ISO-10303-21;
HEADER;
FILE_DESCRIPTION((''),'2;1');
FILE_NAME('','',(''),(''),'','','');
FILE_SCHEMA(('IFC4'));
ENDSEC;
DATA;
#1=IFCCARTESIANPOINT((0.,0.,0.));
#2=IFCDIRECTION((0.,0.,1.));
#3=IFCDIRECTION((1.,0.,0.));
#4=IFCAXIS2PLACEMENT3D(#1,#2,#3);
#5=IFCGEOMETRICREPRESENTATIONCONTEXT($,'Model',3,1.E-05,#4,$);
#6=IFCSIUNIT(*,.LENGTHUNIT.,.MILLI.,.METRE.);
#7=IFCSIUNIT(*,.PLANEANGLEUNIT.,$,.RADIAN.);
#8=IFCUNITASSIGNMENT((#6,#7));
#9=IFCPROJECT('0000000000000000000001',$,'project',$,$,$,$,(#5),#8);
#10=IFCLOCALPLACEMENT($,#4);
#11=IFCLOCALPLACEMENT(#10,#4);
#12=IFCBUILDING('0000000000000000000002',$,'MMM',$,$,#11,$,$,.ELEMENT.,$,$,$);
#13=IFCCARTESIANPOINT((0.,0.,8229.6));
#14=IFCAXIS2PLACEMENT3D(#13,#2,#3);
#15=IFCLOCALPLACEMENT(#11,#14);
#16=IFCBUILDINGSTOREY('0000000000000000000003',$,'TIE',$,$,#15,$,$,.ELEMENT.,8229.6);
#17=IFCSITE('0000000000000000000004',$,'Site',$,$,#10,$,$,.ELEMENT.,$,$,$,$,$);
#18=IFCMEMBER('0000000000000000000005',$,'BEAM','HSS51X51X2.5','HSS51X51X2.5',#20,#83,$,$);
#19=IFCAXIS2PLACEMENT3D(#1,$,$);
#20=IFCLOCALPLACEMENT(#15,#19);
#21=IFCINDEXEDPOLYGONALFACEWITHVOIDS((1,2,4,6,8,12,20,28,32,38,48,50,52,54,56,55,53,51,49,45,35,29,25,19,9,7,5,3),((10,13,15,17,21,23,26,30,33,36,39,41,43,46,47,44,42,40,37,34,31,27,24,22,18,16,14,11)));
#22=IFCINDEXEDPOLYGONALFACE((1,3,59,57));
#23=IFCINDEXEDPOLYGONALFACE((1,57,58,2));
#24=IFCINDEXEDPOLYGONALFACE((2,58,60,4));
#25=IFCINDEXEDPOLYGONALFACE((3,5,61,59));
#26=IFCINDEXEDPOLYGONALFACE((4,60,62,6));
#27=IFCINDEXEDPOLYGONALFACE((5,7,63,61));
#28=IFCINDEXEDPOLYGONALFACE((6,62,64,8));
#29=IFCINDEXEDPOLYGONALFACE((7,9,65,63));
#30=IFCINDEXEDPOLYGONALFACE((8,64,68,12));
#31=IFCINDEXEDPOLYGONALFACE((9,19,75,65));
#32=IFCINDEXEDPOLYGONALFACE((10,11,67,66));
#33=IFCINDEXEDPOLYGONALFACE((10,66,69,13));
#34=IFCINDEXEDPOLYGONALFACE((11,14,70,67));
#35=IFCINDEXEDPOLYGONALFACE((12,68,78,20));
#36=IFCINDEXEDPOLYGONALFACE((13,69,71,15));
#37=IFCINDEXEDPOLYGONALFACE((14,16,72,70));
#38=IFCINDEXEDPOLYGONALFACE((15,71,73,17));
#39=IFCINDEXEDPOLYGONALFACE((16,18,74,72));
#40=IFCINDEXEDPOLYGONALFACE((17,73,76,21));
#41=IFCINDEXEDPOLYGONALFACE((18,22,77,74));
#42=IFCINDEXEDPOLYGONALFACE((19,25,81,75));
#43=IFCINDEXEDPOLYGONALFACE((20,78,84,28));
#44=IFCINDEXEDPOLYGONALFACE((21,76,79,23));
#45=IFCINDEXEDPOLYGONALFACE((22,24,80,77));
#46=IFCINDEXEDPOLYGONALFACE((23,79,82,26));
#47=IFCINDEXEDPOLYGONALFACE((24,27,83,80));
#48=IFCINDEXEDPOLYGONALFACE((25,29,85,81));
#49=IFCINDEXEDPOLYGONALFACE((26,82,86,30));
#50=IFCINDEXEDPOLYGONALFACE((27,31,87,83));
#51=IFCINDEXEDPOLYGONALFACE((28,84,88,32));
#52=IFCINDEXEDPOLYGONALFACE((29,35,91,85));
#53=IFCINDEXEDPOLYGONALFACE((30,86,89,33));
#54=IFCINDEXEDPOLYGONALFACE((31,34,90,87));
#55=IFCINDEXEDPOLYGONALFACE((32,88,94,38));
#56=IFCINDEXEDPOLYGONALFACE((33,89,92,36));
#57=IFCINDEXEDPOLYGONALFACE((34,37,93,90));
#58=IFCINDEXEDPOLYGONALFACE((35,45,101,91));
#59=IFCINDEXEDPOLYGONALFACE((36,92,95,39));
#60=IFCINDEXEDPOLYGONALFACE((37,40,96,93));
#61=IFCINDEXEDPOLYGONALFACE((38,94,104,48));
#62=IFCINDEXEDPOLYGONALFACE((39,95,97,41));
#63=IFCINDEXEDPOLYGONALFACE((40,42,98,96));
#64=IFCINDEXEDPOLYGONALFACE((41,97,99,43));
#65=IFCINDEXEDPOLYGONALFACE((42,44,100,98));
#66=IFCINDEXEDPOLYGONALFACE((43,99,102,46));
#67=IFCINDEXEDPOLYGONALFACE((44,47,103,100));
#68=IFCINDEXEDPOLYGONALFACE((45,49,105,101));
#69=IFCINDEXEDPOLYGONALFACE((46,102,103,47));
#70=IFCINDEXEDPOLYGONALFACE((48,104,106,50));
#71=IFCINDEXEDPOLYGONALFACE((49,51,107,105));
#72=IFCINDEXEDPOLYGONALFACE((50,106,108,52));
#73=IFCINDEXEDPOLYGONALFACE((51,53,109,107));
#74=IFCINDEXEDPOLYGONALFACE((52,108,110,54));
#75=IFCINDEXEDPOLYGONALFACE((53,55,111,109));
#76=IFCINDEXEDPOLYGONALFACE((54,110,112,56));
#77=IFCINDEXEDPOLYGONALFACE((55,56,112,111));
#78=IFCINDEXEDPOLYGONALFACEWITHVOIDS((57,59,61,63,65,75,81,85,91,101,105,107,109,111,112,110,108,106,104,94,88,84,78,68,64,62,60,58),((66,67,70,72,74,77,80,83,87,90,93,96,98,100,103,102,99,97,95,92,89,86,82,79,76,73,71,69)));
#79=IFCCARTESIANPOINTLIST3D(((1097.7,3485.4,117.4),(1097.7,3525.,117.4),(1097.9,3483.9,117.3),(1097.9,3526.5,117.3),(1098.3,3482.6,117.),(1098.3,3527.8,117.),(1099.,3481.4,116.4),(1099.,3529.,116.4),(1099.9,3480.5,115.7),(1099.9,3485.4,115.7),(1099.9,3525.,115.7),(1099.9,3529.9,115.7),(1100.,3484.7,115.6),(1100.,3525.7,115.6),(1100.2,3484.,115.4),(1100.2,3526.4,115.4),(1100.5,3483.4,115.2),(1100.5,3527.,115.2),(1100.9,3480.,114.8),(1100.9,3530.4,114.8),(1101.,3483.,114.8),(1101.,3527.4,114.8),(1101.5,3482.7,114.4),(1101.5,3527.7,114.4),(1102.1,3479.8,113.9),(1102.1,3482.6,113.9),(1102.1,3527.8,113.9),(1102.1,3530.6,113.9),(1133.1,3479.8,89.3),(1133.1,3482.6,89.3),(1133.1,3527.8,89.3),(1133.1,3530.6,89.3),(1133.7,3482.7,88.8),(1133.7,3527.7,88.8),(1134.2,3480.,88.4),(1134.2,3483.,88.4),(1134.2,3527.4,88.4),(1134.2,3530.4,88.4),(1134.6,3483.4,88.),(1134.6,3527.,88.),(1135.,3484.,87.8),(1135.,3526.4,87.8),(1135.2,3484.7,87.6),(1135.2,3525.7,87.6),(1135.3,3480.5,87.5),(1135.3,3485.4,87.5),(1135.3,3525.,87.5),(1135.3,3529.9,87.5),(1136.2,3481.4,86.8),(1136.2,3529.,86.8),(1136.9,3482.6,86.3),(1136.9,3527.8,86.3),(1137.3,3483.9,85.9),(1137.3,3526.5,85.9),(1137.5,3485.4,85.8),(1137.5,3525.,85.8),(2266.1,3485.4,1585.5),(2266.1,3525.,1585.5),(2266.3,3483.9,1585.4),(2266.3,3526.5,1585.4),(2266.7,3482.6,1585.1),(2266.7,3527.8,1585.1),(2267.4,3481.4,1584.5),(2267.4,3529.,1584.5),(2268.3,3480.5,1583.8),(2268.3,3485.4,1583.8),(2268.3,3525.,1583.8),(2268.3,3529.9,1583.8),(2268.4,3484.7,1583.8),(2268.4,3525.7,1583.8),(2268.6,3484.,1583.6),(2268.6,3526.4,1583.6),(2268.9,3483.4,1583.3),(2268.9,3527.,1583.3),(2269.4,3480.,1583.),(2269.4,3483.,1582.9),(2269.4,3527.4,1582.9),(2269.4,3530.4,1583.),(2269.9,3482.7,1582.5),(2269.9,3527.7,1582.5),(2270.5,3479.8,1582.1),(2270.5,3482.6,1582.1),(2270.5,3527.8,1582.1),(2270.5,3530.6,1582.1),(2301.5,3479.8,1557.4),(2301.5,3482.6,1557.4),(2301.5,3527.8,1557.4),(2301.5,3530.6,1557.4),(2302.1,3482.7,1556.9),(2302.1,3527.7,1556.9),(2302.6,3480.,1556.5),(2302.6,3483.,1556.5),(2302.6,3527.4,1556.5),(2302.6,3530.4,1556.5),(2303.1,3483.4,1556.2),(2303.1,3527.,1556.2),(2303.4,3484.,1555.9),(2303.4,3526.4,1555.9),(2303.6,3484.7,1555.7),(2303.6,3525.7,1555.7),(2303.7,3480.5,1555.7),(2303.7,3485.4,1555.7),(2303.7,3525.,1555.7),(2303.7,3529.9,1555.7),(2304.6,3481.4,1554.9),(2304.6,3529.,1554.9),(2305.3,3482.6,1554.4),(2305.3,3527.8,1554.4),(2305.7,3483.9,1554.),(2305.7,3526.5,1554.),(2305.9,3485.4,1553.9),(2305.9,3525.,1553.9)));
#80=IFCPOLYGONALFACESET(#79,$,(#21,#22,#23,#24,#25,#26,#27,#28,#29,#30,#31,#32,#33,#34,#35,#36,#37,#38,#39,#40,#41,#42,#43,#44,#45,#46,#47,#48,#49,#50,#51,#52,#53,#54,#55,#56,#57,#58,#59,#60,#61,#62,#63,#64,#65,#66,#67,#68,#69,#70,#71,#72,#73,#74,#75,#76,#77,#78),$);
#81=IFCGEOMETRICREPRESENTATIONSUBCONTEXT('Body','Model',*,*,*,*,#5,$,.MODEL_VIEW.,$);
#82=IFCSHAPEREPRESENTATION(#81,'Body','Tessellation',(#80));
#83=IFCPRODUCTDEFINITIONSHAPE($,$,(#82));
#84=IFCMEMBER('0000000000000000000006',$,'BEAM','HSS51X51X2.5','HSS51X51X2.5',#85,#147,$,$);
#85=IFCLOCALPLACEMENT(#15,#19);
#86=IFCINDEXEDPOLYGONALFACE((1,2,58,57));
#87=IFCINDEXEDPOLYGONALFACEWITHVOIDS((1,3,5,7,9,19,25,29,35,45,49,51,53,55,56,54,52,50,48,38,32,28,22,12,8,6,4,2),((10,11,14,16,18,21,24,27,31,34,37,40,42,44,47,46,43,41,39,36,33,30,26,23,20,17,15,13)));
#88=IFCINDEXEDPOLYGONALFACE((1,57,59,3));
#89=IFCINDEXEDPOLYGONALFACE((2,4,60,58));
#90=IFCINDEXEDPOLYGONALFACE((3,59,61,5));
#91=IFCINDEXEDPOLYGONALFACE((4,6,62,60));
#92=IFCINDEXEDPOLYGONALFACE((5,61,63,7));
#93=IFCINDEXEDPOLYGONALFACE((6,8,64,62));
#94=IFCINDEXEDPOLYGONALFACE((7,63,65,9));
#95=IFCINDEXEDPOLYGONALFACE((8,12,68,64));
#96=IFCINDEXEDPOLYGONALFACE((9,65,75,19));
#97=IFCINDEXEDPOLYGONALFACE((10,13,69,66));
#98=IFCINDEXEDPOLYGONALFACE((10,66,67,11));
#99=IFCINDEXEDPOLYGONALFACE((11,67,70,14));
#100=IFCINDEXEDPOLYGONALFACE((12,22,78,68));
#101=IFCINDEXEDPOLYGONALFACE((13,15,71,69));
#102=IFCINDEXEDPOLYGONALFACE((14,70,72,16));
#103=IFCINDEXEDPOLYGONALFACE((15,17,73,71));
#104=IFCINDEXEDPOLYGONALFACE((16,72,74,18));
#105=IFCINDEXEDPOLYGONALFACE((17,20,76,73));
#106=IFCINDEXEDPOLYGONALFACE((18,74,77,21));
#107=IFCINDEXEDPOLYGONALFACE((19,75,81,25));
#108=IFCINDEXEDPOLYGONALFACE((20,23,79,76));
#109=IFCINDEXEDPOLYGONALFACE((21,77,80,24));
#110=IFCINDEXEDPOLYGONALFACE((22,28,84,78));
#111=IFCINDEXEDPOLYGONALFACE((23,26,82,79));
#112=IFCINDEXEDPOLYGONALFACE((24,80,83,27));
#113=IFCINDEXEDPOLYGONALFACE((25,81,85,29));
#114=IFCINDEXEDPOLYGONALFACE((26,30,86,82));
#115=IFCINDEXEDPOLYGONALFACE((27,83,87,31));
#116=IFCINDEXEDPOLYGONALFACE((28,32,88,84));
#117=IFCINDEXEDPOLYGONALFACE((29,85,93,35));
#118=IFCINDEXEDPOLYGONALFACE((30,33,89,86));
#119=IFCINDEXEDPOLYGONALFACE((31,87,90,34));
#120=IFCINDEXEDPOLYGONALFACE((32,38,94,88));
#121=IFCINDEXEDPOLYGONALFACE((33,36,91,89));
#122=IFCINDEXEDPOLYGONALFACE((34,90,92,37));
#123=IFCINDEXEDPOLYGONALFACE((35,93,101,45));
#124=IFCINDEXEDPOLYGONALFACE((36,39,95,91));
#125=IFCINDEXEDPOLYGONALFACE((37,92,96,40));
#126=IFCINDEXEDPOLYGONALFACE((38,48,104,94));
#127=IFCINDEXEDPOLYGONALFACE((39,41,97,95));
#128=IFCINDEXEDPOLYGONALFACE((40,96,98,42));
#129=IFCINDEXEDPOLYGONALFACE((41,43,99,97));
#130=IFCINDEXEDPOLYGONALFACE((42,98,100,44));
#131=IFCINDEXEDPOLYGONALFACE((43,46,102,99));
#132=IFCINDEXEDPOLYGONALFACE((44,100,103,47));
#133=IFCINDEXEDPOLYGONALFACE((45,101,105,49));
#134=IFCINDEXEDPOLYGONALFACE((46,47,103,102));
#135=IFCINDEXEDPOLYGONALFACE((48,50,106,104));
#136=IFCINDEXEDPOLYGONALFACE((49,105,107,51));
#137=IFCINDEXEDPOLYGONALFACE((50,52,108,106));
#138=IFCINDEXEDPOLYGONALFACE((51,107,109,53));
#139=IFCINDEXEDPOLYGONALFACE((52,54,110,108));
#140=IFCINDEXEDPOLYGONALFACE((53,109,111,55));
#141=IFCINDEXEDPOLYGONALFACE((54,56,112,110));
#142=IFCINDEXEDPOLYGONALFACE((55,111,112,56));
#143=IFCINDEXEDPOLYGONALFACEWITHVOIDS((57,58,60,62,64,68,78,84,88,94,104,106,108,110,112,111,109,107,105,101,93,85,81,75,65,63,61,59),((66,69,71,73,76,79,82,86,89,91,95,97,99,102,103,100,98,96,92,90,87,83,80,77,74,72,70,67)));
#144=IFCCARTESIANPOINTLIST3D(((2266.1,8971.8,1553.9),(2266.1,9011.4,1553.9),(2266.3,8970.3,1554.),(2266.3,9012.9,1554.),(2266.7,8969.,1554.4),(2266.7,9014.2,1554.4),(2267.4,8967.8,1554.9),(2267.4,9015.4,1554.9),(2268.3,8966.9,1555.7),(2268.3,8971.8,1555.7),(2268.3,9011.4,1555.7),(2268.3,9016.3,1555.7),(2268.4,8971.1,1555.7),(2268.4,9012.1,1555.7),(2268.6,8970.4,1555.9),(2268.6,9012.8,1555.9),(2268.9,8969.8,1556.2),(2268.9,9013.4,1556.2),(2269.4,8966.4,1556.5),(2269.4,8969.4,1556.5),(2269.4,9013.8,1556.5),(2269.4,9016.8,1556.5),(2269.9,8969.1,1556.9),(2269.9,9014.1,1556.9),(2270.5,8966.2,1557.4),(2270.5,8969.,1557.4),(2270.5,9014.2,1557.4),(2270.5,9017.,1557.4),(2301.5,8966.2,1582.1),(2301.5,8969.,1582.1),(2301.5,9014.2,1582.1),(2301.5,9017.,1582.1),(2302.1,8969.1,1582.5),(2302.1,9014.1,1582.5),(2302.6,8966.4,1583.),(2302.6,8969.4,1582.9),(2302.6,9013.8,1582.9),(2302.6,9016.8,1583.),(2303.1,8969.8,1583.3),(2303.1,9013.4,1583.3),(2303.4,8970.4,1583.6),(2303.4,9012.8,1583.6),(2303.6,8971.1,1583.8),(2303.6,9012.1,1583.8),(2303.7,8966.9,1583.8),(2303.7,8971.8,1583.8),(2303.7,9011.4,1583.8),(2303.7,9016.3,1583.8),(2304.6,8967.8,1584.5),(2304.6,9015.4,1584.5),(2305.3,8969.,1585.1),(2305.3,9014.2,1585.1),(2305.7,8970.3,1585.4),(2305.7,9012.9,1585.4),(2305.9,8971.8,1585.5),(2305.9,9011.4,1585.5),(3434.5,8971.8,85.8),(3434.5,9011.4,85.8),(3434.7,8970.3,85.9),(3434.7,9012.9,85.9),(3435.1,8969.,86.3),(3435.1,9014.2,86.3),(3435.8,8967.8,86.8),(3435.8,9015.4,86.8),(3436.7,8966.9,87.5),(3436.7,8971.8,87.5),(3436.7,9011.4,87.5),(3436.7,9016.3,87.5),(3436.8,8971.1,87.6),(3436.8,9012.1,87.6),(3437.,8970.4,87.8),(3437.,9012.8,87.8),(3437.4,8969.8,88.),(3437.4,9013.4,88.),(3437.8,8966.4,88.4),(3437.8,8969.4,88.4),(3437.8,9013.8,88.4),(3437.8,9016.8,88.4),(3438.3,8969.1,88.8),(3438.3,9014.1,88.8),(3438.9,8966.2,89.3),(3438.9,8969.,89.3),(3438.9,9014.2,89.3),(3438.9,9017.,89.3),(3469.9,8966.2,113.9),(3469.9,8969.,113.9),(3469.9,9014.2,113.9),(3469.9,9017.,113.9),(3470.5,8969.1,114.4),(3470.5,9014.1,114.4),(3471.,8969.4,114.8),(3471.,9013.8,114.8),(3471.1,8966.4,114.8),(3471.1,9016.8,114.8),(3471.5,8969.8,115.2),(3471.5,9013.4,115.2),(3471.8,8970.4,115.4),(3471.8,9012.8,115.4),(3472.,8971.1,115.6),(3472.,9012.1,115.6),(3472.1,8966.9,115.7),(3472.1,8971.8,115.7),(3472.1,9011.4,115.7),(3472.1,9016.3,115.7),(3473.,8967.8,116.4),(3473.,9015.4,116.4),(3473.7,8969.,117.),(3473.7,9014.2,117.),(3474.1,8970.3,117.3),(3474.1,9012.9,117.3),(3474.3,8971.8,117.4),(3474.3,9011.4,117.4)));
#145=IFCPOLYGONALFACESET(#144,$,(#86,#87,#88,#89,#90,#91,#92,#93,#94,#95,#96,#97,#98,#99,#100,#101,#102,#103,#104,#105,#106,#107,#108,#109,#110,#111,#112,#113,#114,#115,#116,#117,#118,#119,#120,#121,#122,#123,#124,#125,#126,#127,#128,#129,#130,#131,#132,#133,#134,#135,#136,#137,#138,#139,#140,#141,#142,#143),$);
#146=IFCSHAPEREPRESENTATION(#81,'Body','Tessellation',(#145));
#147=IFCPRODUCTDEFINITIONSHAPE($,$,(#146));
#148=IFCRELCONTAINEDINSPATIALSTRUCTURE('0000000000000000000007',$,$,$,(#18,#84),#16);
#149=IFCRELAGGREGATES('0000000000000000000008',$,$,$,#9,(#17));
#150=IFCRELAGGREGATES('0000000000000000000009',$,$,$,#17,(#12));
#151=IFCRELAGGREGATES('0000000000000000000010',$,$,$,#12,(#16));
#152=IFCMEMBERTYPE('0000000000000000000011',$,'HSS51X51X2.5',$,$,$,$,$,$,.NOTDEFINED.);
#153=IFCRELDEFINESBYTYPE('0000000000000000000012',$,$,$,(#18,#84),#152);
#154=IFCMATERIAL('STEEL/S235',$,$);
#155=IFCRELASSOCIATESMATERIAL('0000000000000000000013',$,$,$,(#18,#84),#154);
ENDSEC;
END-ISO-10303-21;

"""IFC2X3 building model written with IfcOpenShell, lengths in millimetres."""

from ifc_helpers import new_model, si_unit, frame, origin_with_axes, origin_2d_with_axis, place, context, subcontext, project, spatial, hollow_rectangle, extrude, material, type_object, element, save


model = new_model("IFC2X3")

# Units and contexts
model_context = context("Model", 3, precision=1e-05, world=origin_with_axes())
body_context = subcontext(model_context, "Body", "Model", "MODEL_VIEW")
ifc_project = project(units=[si_unit("LENGTHUNIT", "METRE", prefix="MILLI"), si_unit("PLANEANGLEUNIT", "RADIAN")], contexts=[model_context])

# Site, building, storey
site_placement = place(None, origin_with_axes())
site = spatial("IfcSite", under=ifc_project, at=site_placement, Name="Site", CompositionType="ELEMENT")
building_placement = place(site_placement, origin_with_axes())
building = spatial("IfcBuilding", under=site, at=building_placement, Name="MMM", CompositionType="ELEMENT")
storey_placement = place(building_placement, frame((0.0, 0.0, 8229.6), z_axis=(0.0, 0.0, 1.0), x_axis=(1.0, 0.0, 0.0)))
storey = spatial("IfcBuildingStorey", under=building, at=storey_placement, Name="TIE", CompositionType="ELEMENT", Elevation=8229.6)

# Shared definitions
ifc_material = material(Name="STEEL/S235")

# Members
member_type_1 = type_object("IfcMemberType", Name="HSS51X51X2.5", PredefinedType="NOTDEFINED")
for number, where, z_axis, x_axis, name in (
    (1, (1117.6, 3505.2, 101.6), (-0.782448, 0.0, 0.622716), (0.622716, 0.0, 0.782448), "BEAM"),
    (2, (3454.4, 8991.6, 101.6), (0.782448, 0.0, 0.622716), (-0.622716, 0.0, 0.782448), "BEAM"),
):
    element("IfcMember", number, at=place(storey_placement, frame(where, z_axis=z_axis, x_axis=x_axis)), inside=storey, type_object=member_type_1, material=ifc_material, Name=name, Description="HSS51X51X2.5", ObjectType="HSS51X51X2.5", context=body_context, shape_type="SweptSolid", body=[
        extrude(hollow_rectangle(XDim=50.8, YDim=50.8, WallThickness=2.8, InnerFilletRadius=2.8, OuterFilletRadius=5.6, at=origin_2d_with_axis()), frame((1876.3, 0.0, 0.0), z_axis=(-1.0, 0.0, 0.0), x_axis=(0.0, -1.0, 0.0)), (0.0, 0.0, 1.0), 1876.3),
    ])

save(model, "model.ifc")
